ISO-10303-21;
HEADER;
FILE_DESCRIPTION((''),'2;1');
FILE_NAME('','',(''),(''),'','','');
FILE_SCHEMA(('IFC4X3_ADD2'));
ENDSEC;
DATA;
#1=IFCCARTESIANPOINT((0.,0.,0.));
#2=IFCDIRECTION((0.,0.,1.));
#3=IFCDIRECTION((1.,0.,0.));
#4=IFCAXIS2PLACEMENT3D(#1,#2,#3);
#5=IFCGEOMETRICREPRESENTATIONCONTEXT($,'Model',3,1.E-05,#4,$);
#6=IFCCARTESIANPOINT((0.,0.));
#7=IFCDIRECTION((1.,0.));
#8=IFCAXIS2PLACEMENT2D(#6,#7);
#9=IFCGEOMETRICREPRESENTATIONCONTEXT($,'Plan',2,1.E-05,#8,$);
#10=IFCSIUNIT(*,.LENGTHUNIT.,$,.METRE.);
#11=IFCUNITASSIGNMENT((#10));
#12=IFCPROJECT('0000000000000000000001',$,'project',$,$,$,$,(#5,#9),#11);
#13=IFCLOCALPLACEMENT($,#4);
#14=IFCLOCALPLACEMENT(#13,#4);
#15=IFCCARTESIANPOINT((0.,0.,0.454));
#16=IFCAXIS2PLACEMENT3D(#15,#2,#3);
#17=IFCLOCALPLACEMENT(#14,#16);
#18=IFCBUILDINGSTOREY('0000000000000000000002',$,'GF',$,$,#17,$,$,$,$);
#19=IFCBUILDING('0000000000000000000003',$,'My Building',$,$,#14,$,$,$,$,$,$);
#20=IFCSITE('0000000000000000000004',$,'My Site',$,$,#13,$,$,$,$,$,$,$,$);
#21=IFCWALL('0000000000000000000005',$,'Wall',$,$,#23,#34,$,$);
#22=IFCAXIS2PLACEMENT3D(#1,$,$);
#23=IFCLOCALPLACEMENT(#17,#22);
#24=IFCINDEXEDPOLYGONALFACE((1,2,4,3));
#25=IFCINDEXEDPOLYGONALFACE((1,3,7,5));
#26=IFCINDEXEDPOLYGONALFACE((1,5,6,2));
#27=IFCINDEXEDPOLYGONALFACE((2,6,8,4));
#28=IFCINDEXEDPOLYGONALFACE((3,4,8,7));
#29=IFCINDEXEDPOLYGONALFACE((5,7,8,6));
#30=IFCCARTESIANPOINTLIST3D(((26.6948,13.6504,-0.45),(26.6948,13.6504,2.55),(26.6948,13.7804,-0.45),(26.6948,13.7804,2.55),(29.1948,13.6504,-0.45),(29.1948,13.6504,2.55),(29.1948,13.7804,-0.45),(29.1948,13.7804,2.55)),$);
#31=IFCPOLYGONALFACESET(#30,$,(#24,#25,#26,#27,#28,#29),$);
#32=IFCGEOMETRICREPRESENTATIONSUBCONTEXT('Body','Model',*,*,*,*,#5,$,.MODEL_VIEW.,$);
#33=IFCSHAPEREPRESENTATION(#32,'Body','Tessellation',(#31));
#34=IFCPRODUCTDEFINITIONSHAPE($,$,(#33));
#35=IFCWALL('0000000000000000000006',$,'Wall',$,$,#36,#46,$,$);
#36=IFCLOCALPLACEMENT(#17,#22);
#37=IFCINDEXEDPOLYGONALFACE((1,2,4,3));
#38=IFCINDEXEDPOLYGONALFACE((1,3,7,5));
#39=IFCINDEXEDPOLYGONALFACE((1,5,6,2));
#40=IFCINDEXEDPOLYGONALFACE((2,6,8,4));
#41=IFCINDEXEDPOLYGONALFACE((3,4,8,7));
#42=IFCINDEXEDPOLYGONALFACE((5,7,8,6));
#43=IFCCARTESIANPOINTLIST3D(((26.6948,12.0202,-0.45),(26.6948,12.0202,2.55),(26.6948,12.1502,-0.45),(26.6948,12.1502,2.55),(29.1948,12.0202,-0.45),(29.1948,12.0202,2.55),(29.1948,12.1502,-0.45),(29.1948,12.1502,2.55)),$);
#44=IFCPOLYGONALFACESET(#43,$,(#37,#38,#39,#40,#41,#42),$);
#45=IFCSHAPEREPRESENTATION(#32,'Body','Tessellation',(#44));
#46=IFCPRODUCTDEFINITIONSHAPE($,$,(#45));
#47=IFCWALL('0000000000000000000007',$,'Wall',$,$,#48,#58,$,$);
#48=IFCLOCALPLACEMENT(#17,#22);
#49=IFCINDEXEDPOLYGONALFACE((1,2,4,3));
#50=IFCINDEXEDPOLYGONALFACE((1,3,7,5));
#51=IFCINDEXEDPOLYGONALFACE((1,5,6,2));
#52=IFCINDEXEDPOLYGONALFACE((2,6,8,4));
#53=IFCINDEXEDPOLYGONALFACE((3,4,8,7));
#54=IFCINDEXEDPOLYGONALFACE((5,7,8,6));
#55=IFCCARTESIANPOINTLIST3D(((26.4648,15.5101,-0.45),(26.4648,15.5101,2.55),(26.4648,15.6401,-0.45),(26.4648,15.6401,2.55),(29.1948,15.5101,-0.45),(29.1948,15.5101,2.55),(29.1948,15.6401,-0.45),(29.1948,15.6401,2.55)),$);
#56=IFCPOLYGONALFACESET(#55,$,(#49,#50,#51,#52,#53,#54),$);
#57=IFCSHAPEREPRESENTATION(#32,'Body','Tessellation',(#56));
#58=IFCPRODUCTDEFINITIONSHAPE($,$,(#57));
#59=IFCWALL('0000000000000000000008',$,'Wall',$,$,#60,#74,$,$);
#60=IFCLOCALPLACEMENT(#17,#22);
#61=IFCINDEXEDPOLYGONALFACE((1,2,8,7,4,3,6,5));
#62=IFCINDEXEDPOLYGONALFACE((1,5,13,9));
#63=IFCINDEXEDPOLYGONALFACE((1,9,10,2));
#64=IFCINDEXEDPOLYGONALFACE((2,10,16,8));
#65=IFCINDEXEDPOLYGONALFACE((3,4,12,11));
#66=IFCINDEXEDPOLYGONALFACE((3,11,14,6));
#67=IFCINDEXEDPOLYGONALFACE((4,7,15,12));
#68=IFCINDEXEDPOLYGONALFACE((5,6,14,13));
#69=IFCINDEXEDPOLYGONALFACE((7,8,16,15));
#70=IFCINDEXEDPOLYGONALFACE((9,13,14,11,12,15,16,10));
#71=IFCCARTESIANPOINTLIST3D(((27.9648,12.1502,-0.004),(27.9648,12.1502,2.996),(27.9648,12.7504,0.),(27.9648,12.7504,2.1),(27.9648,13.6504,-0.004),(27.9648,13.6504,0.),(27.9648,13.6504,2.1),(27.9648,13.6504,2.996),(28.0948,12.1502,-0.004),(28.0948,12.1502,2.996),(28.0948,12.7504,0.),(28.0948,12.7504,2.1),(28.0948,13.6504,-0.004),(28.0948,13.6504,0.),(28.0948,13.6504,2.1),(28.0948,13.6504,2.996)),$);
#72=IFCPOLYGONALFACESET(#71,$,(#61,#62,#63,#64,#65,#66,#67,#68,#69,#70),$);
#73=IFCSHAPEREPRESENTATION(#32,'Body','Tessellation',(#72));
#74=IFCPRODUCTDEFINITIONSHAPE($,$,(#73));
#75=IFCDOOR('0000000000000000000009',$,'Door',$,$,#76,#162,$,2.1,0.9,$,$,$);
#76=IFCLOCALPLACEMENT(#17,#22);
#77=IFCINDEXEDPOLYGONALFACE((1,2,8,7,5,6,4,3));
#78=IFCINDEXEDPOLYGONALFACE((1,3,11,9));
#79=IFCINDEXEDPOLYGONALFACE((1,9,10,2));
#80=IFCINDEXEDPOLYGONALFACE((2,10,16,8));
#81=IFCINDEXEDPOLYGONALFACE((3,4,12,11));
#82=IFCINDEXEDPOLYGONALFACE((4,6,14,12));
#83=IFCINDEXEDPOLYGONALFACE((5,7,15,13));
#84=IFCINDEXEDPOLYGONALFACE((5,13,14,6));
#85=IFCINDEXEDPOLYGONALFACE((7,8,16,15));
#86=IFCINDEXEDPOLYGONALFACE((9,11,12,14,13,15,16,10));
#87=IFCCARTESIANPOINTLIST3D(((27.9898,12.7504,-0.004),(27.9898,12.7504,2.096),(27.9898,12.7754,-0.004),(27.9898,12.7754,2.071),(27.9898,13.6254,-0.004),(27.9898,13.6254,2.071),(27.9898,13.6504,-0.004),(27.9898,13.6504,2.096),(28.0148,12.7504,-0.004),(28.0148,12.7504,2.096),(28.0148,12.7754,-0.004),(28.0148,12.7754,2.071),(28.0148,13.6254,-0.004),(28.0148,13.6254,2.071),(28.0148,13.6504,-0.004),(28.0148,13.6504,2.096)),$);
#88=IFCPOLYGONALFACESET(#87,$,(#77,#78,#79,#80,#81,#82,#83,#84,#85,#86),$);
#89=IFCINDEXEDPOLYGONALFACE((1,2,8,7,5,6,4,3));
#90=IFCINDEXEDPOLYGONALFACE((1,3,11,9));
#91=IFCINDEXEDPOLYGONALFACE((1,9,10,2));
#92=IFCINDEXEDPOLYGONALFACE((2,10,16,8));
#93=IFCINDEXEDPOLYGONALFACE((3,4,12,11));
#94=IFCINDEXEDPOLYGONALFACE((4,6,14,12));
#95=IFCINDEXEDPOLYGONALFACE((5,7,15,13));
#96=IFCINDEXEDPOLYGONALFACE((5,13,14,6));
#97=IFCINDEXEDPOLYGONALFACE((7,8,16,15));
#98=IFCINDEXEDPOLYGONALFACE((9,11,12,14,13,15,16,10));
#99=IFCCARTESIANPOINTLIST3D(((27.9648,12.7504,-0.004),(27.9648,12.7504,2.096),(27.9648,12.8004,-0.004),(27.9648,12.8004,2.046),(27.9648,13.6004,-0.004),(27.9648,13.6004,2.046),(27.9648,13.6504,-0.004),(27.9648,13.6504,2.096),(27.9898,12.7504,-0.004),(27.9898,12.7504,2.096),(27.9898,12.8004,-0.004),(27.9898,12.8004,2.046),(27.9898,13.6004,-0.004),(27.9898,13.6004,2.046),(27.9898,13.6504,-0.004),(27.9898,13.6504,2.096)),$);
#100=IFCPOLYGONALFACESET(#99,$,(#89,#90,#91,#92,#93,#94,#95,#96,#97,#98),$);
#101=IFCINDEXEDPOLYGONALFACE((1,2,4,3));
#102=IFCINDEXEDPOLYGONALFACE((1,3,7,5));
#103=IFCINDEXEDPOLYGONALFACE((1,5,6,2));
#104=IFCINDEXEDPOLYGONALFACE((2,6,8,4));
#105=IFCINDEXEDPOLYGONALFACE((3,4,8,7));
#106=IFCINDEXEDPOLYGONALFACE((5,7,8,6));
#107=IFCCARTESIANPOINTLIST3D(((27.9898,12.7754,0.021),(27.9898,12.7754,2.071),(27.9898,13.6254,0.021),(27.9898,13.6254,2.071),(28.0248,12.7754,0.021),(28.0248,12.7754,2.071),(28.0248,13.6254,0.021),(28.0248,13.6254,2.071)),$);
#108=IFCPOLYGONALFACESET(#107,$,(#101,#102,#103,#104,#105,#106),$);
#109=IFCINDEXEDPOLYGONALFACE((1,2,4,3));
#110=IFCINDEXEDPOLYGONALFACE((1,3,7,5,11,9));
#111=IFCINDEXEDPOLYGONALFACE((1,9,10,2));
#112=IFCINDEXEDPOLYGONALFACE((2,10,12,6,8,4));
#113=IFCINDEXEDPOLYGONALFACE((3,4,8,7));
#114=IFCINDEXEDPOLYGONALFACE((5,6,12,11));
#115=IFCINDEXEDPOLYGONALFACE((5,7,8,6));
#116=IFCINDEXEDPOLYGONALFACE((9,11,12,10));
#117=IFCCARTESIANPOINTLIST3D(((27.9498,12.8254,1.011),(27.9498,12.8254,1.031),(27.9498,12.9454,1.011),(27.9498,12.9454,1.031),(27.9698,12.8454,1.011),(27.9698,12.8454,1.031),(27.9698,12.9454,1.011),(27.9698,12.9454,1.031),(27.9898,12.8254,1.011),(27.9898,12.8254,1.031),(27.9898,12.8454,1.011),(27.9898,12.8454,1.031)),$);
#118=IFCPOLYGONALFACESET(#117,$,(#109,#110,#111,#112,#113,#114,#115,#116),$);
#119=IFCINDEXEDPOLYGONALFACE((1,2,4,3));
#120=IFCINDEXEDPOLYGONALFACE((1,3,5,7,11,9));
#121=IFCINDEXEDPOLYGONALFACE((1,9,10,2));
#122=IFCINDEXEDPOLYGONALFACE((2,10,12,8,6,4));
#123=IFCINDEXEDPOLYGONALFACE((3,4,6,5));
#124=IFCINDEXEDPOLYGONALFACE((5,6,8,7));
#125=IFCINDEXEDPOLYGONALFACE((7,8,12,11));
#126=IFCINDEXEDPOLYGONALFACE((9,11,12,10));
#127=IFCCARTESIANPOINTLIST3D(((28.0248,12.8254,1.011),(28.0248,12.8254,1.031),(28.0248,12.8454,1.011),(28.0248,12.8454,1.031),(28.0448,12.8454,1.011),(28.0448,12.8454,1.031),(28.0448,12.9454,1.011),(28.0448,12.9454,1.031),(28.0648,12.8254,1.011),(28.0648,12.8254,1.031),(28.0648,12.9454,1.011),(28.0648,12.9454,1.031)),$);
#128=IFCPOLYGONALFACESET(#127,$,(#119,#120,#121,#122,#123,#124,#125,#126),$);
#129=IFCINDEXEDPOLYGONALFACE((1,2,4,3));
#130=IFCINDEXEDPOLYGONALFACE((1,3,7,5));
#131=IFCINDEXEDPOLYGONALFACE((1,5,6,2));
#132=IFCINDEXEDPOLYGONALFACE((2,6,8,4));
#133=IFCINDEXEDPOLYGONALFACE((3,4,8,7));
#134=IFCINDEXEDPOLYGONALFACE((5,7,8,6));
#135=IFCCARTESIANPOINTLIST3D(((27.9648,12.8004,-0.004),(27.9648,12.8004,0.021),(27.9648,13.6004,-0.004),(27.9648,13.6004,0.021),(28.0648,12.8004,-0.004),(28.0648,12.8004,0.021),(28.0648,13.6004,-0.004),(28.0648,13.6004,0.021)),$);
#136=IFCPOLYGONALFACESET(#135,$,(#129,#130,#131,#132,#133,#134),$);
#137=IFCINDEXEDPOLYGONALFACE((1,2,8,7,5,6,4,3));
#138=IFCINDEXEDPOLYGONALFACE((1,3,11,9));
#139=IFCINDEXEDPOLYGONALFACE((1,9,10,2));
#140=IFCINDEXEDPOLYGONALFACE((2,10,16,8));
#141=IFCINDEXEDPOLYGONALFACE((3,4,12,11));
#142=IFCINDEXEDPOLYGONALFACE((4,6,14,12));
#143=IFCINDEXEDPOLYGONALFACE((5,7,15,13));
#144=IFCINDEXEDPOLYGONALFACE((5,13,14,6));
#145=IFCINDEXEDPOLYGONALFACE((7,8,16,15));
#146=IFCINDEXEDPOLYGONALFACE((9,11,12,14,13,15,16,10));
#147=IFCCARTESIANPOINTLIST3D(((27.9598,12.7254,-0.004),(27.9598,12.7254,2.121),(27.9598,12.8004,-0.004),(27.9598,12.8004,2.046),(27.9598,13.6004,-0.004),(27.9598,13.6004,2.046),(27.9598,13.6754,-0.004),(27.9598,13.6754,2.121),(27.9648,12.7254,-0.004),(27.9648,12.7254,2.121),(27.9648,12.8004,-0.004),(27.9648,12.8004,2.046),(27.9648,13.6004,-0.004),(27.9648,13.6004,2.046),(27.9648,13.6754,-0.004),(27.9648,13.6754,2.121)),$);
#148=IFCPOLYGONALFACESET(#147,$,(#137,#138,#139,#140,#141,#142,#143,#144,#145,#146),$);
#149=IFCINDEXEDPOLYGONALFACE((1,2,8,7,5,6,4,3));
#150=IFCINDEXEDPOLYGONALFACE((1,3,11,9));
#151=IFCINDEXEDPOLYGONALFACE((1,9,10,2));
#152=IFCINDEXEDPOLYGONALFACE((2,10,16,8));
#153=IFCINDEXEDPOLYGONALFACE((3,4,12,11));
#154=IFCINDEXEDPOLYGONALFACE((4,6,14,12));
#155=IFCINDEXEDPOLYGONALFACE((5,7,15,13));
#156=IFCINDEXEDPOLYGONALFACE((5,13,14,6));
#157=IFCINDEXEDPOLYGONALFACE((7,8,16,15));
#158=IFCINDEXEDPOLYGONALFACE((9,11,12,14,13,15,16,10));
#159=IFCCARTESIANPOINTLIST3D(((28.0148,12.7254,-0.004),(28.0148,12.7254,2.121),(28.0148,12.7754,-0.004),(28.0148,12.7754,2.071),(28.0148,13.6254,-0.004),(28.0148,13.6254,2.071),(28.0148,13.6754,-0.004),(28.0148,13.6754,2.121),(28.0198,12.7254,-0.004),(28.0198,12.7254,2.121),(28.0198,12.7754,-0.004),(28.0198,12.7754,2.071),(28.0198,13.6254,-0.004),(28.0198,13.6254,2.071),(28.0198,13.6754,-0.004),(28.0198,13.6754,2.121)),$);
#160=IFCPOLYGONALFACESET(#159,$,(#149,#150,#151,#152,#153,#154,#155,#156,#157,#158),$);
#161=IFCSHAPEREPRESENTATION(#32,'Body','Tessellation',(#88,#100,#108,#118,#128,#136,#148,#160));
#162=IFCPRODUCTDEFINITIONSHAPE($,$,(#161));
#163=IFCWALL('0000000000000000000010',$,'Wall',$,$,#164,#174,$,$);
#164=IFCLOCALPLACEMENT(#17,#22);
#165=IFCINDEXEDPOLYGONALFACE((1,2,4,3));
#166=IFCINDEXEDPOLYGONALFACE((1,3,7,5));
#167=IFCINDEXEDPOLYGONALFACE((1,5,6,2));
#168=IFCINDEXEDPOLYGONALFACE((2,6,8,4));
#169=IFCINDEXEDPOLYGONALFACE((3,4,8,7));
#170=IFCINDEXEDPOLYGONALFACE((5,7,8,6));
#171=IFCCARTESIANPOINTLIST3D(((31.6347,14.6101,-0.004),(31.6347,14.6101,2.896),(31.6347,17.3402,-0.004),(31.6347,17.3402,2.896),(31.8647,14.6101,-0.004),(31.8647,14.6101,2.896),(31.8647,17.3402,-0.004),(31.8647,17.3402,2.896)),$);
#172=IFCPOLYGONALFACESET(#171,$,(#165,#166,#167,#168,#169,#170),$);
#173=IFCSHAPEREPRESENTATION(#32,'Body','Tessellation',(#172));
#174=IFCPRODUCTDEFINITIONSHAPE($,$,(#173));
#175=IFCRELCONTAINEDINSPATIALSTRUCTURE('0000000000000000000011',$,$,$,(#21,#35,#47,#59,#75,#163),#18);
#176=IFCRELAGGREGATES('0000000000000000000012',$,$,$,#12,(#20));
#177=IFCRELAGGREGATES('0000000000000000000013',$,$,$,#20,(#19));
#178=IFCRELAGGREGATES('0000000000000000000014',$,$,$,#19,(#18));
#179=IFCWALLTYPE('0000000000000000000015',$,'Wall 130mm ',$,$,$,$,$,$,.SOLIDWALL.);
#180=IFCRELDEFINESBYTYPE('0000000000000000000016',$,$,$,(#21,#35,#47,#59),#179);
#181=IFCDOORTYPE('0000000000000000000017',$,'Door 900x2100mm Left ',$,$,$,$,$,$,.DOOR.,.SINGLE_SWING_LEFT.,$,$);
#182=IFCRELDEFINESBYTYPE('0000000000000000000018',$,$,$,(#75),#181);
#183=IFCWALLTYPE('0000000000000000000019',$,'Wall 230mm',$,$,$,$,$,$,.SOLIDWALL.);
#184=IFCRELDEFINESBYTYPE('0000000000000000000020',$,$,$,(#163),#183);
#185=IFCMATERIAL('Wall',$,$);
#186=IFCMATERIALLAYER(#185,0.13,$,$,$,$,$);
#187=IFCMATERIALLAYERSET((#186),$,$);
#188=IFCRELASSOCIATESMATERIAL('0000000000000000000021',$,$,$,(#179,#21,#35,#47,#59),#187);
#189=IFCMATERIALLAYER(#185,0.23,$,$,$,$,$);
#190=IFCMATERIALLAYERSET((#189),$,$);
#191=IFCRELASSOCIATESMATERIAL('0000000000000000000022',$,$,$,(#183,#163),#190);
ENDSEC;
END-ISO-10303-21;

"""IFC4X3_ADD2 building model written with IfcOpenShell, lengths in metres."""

from ifc_helpers import new_model, entity, si_unit, frame, origin_with_axes, origin_2d_with_axis, place, context, subcontext, project, spatial, line, indexed_curve, outline, extrude, shape, source, transform, mapped, material, layer, layer_set, layer_usage, type_object, type_shapes, element, fill, save


model = new_model("IFC4X3_ADD2")

# Units and contexts
model_context = context("Model", 3, precision=1e-05, world=origin_with_axes())
plan_context = context("Plan", 2, precision=1e-05, world=origin_2d_with_axis())
body_context_1 = subcontext(model_context, "Body", "Model", "MODEL_VIEW")
body_context_2 = subcontext(plan_context, "Body", "Plan", "PLAN_VIEW")
ifc_project = project(units=[si_unit("LENGTHUNIT", "METRE")], contexts=[model_context, plan_context])

# Site, building, storey
site_placement = place(None, origin_with_axes())
site = spatial("IfcSite", under=ifc_project, at=site_placement, Name="My Site")
building_placement = place(site_placement, origin_with_axes())
building = spatial("IfcBuilding", under=site, at=building_placement, Name="My Building")
storey_placement = place(building_placement, frame((0.0, 0.0, 0.454), z_axis=(0.0, 0.0, 1.0), x_axis=(1.0, 0.0, 0.0)))
storey = spatial("IfcBuildingStorey", under=building, at=storey_placement, Name="GF")

# Walls
ifc_material_1 = material(Name="Wall")
ifc_layer_1 = layer(ifc_material_1, 0.13)
ifc_layer_set_1 = layer_set([ifc_layer_1])
ifc_layer_usage_1 = layer_usage(ifc_layer_set_1, "AXIS2", "POSITIVE", 0.0)
wall_type_1 = type_object("IfcWallType", Name="Wall 130mm ", PredefinedType="SOLIDWALL", material=ifc_layer_set_1)
wall_1_placement = place(storey_placement, frame((29.1948, 13.7804, -0.45), z_axis=(0.0, 0.0, 1.0), x_axis=(-1.0, 0.0, 0.0)))
element("IfcWall", 1, at=wall_1_placement, inside=storey, type_object=wall_type_1, material=ifc_layer_usage_1, Name="Wall", context=body_context_1, shape_type="SweptSolid", body=[
    extrude(outline(indexed_curve([(0.0, 0.0), (0.0, 0.13), (2.5, 0.13), (2.5, 0.0), (0.0, 0.0)], self_intersect=False)), origin_with_axes(), (0.0, 0.0, 1.0), 3.0),
])
ifc_layer_usage_2 = layer_usage(ifc_layer_set_1, "AXIS2", "POSITIVE", 0.0)
wall_2_placement = place(storey_placement, frame((29.1948, 12.1502, -0.45), z_axis=(0.0, 0.0, 1.0), x_axis=(-1.0, 0.0, 0.0)))
element("IfcWall", 2, at=wall_2_placement, inside=storey, type_object=wall_type_1, material=ifc_layer_usage_2, Name="Wall", context=body_context_1, shape_type="SweptSolid", body=[
    extrude(outline(indexed_curve([(0.0, 0.0), (0.0, 0.13), (2.5, 0.13), (2.5, 0.0), (0.0, 0.0)], self_intersect=False)), origin_with_axes(), (0.0, 0.0, 1.0), 3.0),
])
ifc_layer_usage_3 = layer_usage(ifc_layer_set_1, "AXIS2", "POSITIVE", 0.0)
wall_3_placement = place(storey_placement, frame((29.1948, 15.6401, -0.45), z_axis=(0.0, 0.0, 1.0), x_axis=(-1.0, 0.0, 0.0)))
element("IfcWall", 3, at=wall_3_placement, inside=storey, type_object=wall_type_1, material=ifc_layer_usage_3, Name="Wall", context=body_context_1, shape_type="SweptSolid", body=[
    extrude(outline(indexed_curve([(0.0, 0.0), (0.0, 0.13), (2.73, 0.13), (2.73, 0.0), (0.0, 0.0)], self_intersect=False)), origin_with_axes(), (0.0, 0.0, 1.0), 3.0),
])

# Wall, opening, door
ifc_layer_usage_4 = layer_usage(ifc_layer_set_1, "AXIS2", "POSITIVE", 0.0)
wall_4_placement = place(storey_placement, frame((27.9648, 13.6504, -0.004), z_axis=(0.0, 0.0, 1.0), x_axis=(0.0, -1.0, 0.0)))
wall_4 = element("IfcWall", 4, at=wall_4_placement, inside=storey, type_object=wall_type_1, material=ifc_layer_usage_4, Name="Wall", context=body_context_1, shape_type="SweptSolid", body=[
    extrude(outline(indexed_curve([(0.0, 0.0), (0.0, 0.13), (1.5002, 0.13), (1.5002, 0.0), (0.0, 0.0)], self_intersect=False)), origin_with_axes(), (0.0, 0.0, 1.0), 3.0),
])
shared_shape_1 = source(origin_with_axes(), body_context_1, "Body", "SweptSolid", [
    extrude(outline(indexed_curve([(0.0, 0.0), (0.9, 0.0), (0.9, 2.1), (0.0, 2.1)], segments=[line(1, 2, 3, 4, 1)])), frame((0.0, -0.6, 0.0), z_axis=(0.0, -1.0, 0.0), x_axis=(1.0, 0.0, 0.0)), (0.0, 0.0, -1.0), 1.2),
])
opening_1_placement = place(wall_4_placement, frame((0.0, 0.0, 0.004), z_axis=(0.0, 0.0, 1.0), x_axis=(1.0, 0.0, 0.0)))
opening_1 = element("IfcOpeningElement", 5, at=opening_1_placement, cuts=wall_4, PredefinedType="OPENING", context=body_context_1, shape_type="MappedRepresentation", body=[
    mapped(shared_shape_1, transform((0.0, 0.0, 0.0), x_axis=(1.0, 0.0, 0.0), y_axis=(0.0, 1.0, 0.0), z_axis=(0.0, 0.0, 1.0), scale=1.0)),
])
door_type = type_object("IfcDoorType", Name="Door 900x2100mm Left ", OperationType="SINGLE_SWING_LEFT", PredefinedType="DOOR")
shared_shape_2 = source(origin_with_axes(), body_context_1, "Body", "SweptSolid", [
    extrude(outline(indexed_curve([(0.0, 0.0), (0.0, 2.1), (0.9, 2.1), (0.9, 0.0), (0.875, 0.0), (0.875, 2.075), (0.025, 2.075), (0.025, 0.0)], segments=[line(1, 2, 3, 4, 5, 6, 7, 8, 1)])), frame((0.0, 0.025, 0.0), z_axis=(0.0, -1.0, 0.0), x_axis=(1.0, 0.0, 0.0)), (0.0, 0.0, -1.0), 0.025),
    extrude(outline(indexed_curve([(0.0, 0.0), (0.0, 2.1), (0.9, 2.1), (0.9, 0.0), (0.85, 0.0), (0.85, 2.05), (0.05, 2.05), (0.05, 0.0)], segments=[line(1, 2, 3, 4, 5, 6, 7, 8, 1)])), frame((0.0, 0.0, 0.0), z_axis=(0.0, -1.0, 0.0), x_axis=(1.0, 0.0, 0.0)), (0.0, 0.0, -1.0), 0.025),
    extrude(outline(indexed_curve([(0.0, 0.0), (0.85, 0.0), (0.85, 0.035), (0.0, 0.035)], segments=[line(1, 2, 3, 4, 1)])), frame((0.025, 0.025, 0.025), z_axis=(0.0, 0.0, 1.0), x_axis=(1.0, 0.0, 0.0)), (0.0, 0.0, 1.0), 2.05),
    extrude(outline(indexed_curve([(0.0, 0.0), (0.0, -0.04), (-0.12, -0.04), (-0.12, -0.02), (-0.02, -0.02), (-0.02, 0.0)], segments=[line(1, 2, 3, 4, 5, 6, 1)])), frame((0.825, 0.025, 1.015), z_axis=(0.0, 0.0, 1.0), x_axis=(1.0, 0.0, 0.0)), (0.0, 0.0, 1.0), 0.02),
    extrude(outline(indexed_curve([(0.0, 0.0), (0.0, 0.04), (-0.12, 0.04), (-0.12, 0.02), (-0.02, 0.02), (-0.02, 0.0)], segments=[line(1, 2, 3, 4, 5, 6, 1)])), frame((0.825, 0.06, 1.015), z_axis=(0.0, 0.0, 1.0), x_axis=(1.0, 0.0, 0.0)), (0.0, 0.0, 1.0), 0.02),
    extrude(outline(indexed_curve([(0.0, 0.0), (0.8, 0.0), (0.8, 0.1), (0.0, 0.1)], segments=[line(1, 2, 3, 4, 1)])), frame((0.05, 0.0, 0.0), z_axis=(0.0, 0.0, 1.0), x_axis=(1.0, 0.0, 0.0)), (0.0, 0.0, 1.0), 0.025),
    extrude(outline(indexed_curve([(0.0, 0.0), (0.0, 2.125), (0.95, 2.125), (0.95, 0.0), (0.875, 0.0), (0.875, 2.05), (0.075, 2.05), (0.075, 0.0)], segments=[line(1, 2, 3, 4, 5, 6, 7, 8, 1)])), frame((-0.025, -0.005, 0.0), z_axis=(0.0, -1.0, 0.0), x_axis=(1.0, 0.0, 0.0)), (0.0, 0.0, -1.0), 0.005),
    extrude(outline(indexed_curve([(0.0, 0.0), (0.0, 2.125), (0.95, 2.125), (0.95, 0.0), (0.9, 0.0), (0.9, 2.075), (0.05, 2.075), (0.05, 0.0)], segments=[line(1, 2, 3, 4, 5, 6, 7, 8, 1)])), frame((-0.025, 0.05, 0.0), z_axis=(0.0, -1.0, 0.0), x_axis=(1.0, 0.0, 0.0)), (0.0, 0.0, -1.0), 0.005),
])
shared_shape_3 = source(origin_with_axes(), body_context_2, "Body", "Curve2D", [
    entity("IfcIndexedPolyCurve", entity("IfcCartesianPointList2D", [[0.0, 0.0], [0.0, 0.05], [0.025, 0.05], [0.025, 0.025], [0.05, 0.025], [0.05, 0.0]]), [entity("IfcLineIndex", [1, 2, 3, 4, 5, 6, 1])]),
    entity("IfcIndexedPolyCurve", entity("IfcCartesianPointList2D", [[0.9, 0.0], [0.9, 0.05], [0.875, 0.05], [0.875, 0.025], [0.85, 0.025], [0.85, 0.0]]), [entity("IfcLineIndex", [1, 2, 3, 4, 5, 6, 1])]),
    entity("IfcTrimmedCurve", entity("IfcEllipse", entity("IfcAxis2Placement2D", entity("IfcCartesianPoint", [0.06, 0.05]), entity("IfcDirection", [1.0, 0.0])), 0.815, 0.85), [entity("IfcCartesianPoint", [0.875, 0.05])], [entity("IfcCartesianPoint", [0.06, 0.9])], True, "CARTESIAN"),
    entity("IfcIndexedPolyCurve", entity("IfcCartesianPointList2D", [[0.025, 0.05], [0.06, 0.05], [0.06, 0.9], [0.025, 0.9]]), [entity("IfcLineIndex", [1, 2, 3, 4, 1])]),
])
type_shapes(door_type, [shared_shape_2, shared_shape_3])
door_placement = place(opening_1_placement, frame((0.0, 0.0, -0.004), z_axis=(0.0, 0.0, 1.0), x_axis=(1.0, 0.0, 0.0)))
door = element("IfcDoor", 6, at=door_placement, inside=storey, type_object=door_type, Name="Door", OverallHeight=2.1, OverallWidth=0.9, shapes=[
    shape(body_context_1, "Body", "MappedRepresentation", [mapped(shared_shape_2, transform((0.0, 0.0, 0.0), x_axis=(1.0, 0.0, 0.0), y_axis=(0.0, 1.0, 0.0), z_axis=(0.0, 0.0, 1.0), scale=1.0))]),
    shape(body_context_2, "Body", "MappedRepresentation", [mapped(shared_shape_3, transform((0.0, 0.0, 0.0), x_axis=(1.0, 0.0, 0.0), y_axis=(0.0, 1.0, 0.0), z_axis=(0.0, 0.0, 1.0), scale=1.0))]),
])
fill(opening_1, door)

# Shared definitions
ifc_layer_2 = layer(ifc_material_1, 0.23)
ifc_layer_set_2 = layer_set([ifc_layer_2])
wall_type_2 = type_object("IfcWallType", Name="Wall 230mm", PredefinedType="SOLIDWALL", material=ifc_layer_set_2)

# Wall
ifc_layer_usage_5 = layer_usage(ifc_layer_set_2, "AXIS2", "POSITIVE", 0.0)
wall_5_placement = place(storey_placement, frame((31.8647, 14.6101, -0.004), z_axis=(0.0, 0.0, 1.0), x_axis=(0.000001, 1.0, 0.0)))
element("IfcWall", 7, at=wall_5_placement, inside=storey, type_object=wall_type_2, material=ifc_layer_usage_5, Name="Wall", context=body_context_1, shape_type="SweptSolid", body=[
    extrude(outline(indexed_curve([(0.0, 0.0), (0.0, 0.23), (2.73, 0.23), (2.73, 0.0), (0.0, 0.0)], self_intersect=False)), origin_with_axes(), (0.0, 0.0, 1.0), 2.9),
])

save(model, "model.ifc")
